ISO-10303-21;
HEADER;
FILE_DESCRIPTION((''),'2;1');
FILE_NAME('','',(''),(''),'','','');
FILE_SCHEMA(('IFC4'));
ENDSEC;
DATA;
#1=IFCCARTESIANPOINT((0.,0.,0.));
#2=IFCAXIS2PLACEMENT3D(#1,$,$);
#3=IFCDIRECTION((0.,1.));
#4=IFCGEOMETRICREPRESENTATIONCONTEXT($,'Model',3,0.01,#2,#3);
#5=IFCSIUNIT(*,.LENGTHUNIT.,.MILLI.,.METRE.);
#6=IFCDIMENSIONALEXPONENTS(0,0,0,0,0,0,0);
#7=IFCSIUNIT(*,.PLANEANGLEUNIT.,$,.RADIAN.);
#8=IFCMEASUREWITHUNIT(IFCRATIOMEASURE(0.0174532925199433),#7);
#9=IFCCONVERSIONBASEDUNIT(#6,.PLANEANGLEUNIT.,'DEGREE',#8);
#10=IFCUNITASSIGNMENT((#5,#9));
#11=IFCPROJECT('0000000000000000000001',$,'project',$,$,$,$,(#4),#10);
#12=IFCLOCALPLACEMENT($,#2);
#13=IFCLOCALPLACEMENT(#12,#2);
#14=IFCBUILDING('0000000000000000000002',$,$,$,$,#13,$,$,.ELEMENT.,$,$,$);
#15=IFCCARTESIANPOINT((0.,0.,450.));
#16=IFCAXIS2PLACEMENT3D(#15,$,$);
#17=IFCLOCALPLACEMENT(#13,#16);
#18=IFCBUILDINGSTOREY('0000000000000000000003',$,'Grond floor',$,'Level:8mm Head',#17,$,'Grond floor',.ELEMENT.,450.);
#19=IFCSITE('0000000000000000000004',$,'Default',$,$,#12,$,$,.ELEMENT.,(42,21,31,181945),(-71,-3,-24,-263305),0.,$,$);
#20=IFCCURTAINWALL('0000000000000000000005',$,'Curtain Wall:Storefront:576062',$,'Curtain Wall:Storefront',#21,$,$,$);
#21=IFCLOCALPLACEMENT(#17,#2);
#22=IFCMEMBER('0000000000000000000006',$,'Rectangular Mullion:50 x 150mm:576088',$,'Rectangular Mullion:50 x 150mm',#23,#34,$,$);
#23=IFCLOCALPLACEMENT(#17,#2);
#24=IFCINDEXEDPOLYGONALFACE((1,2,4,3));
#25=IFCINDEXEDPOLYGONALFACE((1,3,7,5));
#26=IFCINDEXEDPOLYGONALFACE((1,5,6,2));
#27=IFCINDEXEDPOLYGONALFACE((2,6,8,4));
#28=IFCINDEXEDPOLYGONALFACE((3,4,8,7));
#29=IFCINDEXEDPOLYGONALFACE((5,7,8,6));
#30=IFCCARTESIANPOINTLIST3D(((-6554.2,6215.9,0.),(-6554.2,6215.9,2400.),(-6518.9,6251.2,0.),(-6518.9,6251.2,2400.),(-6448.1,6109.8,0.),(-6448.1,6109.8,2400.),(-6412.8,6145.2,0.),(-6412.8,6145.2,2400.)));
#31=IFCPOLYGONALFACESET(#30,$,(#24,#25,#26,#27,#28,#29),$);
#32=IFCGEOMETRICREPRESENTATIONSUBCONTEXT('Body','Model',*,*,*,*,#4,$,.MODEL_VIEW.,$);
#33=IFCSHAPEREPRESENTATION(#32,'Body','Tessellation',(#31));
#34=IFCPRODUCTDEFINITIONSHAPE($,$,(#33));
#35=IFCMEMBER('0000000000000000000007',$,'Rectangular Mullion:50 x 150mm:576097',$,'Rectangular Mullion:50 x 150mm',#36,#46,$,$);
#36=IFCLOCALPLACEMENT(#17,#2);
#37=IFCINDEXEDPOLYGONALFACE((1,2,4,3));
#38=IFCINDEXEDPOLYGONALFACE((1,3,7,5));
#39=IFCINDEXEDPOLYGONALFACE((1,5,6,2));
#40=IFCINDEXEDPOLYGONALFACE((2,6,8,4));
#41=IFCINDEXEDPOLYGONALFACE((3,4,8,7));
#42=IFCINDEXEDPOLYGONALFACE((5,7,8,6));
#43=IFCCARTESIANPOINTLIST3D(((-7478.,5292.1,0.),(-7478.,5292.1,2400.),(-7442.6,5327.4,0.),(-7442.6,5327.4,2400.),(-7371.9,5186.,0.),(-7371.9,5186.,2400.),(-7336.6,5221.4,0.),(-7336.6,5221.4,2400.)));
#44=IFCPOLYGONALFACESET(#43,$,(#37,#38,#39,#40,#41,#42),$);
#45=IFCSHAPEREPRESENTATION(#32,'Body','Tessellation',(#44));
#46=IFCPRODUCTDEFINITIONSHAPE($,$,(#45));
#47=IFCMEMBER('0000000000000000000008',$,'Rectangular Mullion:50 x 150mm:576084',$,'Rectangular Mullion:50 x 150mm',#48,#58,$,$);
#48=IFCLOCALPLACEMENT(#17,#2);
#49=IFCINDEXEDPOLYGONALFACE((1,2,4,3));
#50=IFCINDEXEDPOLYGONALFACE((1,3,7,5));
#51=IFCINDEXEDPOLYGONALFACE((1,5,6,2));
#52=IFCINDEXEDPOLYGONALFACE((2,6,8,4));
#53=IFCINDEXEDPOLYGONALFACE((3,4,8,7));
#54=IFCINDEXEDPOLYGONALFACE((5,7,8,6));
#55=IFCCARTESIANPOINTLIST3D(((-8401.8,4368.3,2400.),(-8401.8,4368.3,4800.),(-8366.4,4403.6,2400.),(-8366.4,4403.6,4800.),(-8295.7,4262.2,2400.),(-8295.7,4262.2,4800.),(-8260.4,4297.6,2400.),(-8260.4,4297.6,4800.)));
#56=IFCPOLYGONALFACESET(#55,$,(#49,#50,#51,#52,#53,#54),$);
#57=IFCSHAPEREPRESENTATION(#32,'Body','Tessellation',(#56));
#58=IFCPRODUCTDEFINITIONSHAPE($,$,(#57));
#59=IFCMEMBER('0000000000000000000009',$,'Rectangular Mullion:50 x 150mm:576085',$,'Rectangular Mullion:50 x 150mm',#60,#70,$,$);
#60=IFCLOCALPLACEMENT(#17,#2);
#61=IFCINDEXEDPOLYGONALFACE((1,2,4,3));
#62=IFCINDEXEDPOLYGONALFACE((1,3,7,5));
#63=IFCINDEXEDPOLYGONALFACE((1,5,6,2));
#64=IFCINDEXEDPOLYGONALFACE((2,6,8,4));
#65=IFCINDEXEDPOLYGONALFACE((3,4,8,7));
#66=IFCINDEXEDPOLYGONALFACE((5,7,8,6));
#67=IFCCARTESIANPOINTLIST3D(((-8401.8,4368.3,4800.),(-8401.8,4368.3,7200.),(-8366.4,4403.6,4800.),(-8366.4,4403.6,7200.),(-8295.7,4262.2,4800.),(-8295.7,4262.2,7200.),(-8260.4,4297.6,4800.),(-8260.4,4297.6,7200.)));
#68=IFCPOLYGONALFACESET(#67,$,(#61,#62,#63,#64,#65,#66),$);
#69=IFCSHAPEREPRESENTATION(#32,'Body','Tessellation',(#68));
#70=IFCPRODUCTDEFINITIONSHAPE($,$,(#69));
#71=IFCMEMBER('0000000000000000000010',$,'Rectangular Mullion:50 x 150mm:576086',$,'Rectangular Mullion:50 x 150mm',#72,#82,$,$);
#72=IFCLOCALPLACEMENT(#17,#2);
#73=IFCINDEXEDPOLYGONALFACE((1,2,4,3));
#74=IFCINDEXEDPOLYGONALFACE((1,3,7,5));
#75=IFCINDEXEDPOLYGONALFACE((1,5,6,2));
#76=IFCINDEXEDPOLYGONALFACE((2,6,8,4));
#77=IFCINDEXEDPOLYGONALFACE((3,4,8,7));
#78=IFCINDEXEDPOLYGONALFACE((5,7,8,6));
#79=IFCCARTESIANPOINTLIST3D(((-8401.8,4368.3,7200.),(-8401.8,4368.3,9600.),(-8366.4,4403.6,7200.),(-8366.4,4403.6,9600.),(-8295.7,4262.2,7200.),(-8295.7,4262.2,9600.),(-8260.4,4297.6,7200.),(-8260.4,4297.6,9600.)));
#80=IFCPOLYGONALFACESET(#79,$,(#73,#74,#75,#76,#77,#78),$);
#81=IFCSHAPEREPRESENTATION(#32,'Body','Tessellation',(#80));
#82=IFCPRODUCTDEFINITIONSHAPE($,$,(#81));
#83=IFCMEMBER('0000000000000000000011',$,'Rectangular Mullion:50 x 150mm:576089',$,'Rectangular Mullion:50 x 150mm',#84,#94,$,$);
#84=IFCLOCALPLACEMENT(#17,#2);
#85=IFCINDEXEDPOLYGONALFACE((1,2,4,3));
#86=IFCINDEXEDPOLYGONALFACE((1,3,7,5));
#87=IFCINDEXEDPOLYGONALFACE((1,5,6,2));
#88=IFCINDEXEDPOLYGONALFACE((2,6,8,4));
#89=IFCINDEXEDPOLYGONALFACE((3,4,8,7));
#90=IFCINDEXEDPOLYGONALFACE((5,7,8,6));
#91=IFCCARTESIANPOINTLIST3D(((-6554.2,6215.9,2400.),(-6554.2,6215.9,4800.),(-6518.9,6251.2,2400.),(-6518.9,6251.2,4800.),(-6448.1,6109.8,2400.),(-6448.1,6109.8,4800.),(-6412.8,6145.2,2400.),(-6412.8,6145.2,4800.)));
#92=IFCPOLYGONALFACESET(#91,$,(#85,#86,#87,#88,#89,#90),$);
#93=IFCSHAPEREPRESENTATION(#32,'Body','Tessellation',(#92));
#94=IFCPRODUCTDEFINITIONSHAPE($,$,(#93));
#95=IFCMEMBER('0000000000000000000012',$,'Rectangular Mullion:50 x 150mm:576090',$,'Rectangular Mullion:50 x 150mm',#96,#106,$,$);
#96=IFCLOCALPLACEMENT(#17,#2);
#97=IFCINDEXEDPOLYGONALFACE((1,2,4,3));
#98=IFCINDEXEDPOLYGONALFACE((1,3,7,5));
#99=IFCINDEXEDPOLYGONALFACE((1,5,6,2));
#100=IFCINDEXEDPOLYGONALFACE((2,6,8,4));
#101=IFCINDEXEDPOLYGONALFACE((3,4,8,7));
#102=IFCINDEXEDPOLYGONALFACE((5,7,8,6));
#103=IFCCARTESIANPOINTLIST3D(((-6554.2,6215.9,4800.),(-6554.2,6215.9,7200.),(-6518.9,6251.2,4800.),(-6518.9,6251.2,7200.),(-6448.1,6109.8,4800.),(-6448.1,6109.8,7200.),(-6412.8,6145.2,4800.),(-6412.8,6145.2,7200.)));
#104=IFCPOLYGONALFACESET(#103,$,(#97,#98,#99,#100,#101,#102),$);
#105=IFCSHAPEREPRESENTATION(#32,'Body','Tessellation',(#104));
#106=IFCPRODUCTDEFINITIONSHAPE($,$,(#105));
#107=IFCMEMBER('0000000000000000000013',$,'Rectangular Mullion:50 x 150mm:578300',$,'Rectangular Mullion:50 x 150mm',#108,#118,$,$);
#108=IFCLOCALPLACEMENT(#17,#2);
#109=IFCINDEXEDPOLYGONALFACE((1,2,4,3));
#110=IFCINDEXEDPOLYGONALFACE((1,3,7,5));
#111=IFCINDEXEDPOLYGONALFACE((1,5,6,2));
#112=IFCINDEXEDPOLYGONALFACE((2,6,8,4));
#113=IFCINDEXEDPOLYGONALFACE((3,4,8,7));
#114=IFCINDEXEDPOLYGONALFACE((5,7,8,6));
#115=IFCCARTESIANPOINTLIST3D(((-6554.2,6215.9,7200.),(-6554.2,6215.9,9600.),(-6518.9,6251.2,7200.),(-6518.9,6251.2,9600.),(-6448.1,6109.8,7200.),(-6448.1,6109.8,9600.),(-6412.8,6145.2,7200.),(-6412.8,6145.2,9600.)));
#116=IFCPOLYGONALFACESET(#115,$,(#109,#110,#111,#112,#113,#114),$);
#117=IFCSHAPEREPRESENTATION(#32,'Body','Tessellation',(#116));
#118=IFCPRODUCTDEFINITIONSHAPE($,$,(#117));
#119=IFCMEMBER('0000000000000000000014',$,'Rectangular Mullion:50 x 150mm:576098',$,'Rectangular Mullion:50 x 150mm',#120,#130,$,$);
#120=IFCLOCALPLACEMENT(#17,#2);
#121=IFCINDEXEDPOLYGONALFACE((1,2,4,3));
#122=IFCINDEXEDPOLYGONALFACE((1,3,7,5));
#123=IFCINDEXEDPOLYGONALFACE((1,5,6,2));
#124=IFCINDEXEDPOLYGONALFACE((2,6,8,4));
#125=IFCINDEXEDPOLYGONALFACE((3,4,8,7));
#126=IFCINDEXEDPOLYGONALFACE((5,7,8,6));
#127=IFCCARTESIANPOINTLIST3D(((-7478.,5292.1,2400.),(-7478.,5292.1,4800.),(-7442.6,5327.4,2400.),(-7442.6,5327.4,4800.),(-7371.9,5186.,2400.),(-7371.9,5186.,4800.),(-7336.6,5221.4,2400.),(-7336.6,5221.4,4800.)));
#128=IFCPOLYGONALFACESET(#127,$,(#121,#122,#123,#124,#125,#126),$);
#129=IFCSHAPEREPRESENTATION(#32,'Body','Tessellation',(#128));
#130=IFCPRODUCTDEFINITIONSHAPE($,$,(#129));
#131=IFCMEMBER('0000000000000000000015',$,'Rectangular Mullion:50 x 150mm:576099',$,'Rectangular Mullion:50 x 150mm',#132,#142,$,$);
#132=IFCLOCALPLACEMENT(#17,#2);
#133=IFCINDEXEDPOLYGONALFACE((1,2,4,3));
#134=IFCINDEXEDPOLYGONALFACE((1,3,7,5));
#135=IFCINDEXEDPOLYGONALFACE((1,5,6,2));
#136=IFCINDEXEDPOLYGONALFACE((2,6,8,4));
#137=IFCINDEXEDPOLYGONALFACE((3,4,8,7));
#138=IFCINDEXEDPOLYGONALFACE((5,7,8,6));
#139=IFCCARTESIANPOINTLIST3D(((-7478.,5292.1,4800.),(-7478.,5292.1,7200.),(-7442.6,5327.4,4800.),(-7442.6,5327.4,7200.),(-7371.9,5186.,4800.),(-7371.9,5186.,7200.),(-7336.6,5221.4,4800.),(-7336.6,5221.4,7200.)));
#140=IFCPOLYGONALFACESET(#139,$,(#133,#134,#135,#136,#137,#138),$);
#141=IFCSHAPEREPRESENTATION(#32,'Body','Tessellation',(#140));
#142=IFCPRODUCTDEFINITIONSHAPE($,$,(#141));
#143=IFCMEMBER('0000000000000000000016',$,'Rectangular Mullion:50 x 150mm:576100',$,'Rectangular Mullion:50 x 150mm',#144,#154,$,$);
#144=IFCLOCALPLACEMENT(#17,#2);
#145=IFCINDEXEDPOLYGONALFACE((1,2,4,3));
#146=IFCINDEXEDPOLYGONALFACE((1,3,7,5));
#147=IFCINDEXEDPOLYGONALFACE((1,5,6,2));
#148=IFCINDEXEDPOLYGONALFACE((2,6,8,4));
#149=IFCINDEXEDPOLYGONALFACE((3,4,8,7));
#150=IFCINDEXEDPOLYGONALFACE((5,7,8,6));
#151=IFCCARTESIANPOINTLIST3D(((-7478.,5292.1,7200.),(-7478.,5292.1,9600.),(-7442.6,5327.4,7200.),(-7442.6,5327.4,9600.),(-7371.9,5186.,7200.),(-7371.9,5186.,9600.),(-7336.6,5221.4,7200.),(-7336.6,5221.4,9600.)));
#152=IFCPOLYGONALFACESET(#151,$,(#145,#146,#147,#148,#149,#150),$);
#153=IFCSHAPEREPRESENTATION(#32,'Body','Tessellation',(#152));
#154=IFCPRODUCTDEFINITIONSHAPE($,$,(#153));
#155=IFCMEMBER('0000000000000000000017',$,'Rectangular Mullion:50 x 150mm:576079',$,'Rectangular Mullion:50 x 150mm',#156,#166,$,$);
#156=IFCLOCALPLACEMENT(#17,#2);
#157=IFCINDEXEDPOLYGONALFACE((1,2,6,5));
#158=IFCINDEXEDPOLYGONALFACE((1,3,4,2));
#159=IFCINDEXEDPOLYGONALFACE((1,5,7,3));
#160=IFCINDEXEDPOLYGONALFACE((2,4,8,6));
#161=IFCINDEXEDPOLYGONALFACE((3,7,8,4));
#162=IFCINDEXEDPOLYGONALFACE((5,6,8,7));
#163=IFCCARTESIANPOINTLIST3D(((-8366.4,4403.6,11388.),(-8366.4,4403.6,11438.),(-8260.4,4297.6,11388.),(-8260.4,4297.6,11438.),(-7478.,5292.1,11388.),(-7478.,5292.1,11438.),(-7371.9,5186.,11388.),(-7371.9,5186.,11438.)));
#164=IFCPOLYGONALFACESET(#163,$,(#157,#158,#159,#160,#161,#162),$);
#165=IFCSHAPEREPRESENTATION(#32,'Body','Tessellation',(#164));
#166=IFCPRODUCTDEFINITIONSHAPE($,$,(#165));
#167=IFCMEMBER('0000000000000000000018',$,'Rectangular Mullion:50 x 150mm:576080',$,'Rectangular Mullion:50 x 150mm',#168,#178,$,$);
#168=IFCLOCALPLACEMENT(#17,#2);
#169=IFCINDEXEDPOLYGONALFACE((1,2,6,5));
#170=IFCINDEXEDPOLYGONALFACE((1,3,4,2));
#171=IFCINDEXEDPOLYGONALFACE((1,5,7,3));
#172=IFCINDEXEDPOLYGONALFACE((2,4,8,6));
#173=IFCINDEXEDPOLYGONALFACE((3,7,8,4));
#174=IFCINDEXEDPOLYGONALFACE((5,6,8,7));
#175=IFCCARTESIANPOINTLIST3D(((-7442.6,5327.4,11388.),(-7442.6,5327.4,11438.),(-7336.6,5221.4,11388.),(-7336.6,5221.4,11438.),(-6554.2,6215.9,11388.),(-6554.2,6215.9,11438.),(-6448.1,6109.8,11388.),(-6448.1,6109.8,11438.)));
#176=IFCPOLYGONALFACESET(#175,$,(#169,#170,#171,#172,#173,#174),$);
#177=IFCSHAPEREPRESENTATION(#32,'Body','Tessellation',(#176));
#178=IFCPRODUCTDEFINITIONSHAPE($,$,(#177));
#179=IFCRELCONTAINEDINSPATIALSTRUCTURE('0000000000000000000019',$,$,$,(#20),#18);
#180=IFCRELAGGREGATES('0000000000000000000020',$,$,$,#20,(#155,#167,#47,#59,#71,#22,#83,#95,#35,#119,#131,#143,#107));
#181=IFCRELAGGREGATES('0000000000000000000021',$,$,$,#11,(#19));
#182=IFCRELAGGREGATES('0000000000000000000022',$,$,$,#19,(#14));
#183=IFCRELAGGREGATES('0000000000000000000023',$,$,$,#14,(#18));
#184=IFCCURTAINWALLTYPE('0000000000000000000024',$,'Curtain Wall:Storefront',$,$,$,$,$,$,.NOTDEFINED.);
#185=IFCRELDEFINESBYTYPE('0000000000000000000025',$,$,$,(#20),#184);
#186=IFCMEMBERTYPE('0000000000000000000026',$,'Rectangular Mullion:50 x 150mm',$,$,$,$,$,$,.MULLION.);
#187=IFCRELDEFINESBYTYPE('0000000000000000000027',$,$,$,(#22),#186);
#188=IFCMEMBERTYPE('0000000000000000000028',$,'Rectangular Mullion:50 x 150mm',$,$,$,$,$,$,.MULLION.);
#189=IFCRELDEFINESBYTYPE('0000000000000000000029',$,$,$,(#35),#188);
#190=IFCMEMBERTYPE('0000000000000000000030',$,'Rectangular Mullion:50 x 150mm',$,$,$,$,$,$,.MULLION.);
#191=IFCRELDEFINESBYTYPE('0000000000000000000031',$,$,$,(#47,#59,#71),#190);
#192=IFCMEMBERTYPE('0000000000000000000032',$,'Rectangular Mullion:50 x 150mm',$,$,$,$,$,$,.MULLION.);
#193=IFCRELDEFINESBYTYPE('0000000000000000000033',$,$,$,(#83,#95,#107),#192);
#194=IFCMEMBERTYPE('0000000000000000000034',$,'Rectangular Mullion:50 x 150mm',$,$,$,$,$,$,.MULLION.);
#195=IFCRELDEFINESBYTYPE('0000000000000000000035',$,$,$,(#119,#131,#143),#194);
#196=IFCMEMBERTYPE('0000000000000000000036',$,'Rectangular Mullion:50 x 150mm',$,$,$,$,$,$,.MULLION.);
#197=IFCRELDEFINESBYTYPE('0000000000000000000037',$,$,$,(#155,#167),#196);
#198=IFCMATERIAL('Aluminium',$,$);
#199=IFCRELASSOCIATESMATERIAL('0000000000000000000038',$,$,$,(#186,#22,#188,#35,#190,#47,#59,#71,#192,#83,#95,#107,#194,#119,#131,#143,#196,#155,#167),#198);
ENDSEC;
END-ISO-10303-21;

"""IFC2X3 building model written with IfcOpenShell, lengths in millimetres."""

from ifc_helpers import new_model, entity, si_unit, converted_unit, direction, frame, origin, origin_2d_with_axis, place, context, subcontext, project, spatial, rectangle, extrude, source, transform, mapped, material, type_object, type_shapes, element, aggregate, save


model = new_model("IFC2X3")

# Units and contexts
model_context = context("Model", 3, precision=0.01, world=origin(), true_north=direction((0.0, 1.0)))
body_context = subcontext(model_context, "Body", "Model", "MODEL_VIEW")
ifc_project = project(units=[si_unit("LENGTHUNIT", "METRE", prefix="MILLI"), converted_unit("PLANEANGLEUNIT", "DEGREE", entity("IfcRatioMeasure", 0.0174532925199433), si_unit("PLANEANGLEUNIT", "RADIAN"), dimensions=[0, 0, 0, 0, 0, 0, 0])], contexts=[model_context])

# Site, building, storey
site_placement = place(None, origin())
site = spatial("IfcSite", under=ifc_project, at=site_placement, Name="Default", CompositionType="ELEMENT", RefLatitude=(42, 21, 31, 181945), RefLongitude=(-71, -3, -24, -263305), RefElevation=0.0)
building_placement = place(site_placement, origin())
building = spatial("IfcBuilding", under=site, at=building_placement, CompositionType="ELEMENT")
storey_placement = place(building_placement, frame((0.0, 0.0, 450.0)))
storey = spatial("IfcBuildingStorey", under=building, at=storey_placement, Name="Grond floor", ObjectType="Level:8mm Head", LongName="Grond floor", CompositionType="ELEMENT", Elevation=450.0)

# Curtain wall, members
curtain_wall_type = type_object("IfcCurtainWallType", Name="Curtain Wall:Storefront", PredefinedType="NOTDEFINED")
curtain_wall_placement = place(storey_placement, frame((0.0, 0.0, -450.0)))
curtain_wall = element("IfcCurtainWall", 1, at=curtain_wall_placement, inside=storey, type_object=curtain_wall_type, Name="Curtain Wall:Storefront:576062", ObjectType="Curtain Wall:Storefront")
ifc_material_1 = material(Name="Aluminium")
member_type_1 = type_object("IfcMemberType", Name="Rectangular Mullion:50 x 150mm", PredefinedType="MULLION", material=ifc_material_1)
shared_shape_1 = source(origin(), body_context, "Body", "SweptSolid", [
    extrude(rectangle(XDim=150.0, YDim=50.0, at=origin_2d_with_axis()), frame((-25.0, 0.0, -2400.0), z_axis=(0.0, 0.0, 1.0), x_axis=(0.0, -1.0, 0.0)), (0.0, 0.0, 1.0), 2400.0),
])
type_shapes(member_type_1, [shared_shape_1])
member_1_placement = place(storey_placement, frame((-6465.8, 6198.2, 2400.0), z_axis=(0.0, 0.0, 1.0), x_axis=(0.707107, 0.707107, 0.0)))
member_1 = element("IfcMember", 2, at=member_1_placement, type_object=member_type_1, material=ifc_material_1, Name="Rectangular Mullion:50 x 150mm:576088", ObjectType="Rectangular Mullion:50 x 150mm", context=body_context, shape_type="MappedRepresentation", body=[
    mapped(shared_shape_1, transform((0.0, 0.0, 0.0), scale=1.0)),
])
member_type_2 = type_object("IfcMemberType", Name="Rectangular Mullion:50 x 150mm", PredefinedType="MULLION", material=ifc_material_1)
shared_shape_2 = source(origin(), body_context, "Body", "SweptSolid", [
    extrude(rectangle(XDim=150.0, YDim=50.0, at=origin_2d_with_axis()), frame((0.0, 0.0, -2400.0), z_axis=(0.0, 0.0, 1.0), x_axis=(0.0, -1.0, 0.0)), (0.0, 0.0, 1.0), 2400.0),
])
type_shapes(member_type_2, [shared_shape_2])
member_2_placement = place(storey_placement, frame((-7407.3, 5256.7, 0.0), z_axis=(0.0, 0.0, -1.0), x_axis=(-0.707107, -0.707107, 0.0)))
member_2 = element("IfcMember", 3, at=member_2_placement, type_object=member_type_2, material=ifc_material_1, Name="Rectangular Mullion:50 x 150mm:576097", ObjectType="Rectangular Mullion:50 x 150mm", context=body_context, shape_type="MappedRepresentation", body=[
    mapped(shared_shape_2, transform((0.0, 0.0, 0.0), scale=1.0)),
])
member_type_3 = type_object("IfcMemberType", Name="Rectangular Mullion:50 x 150mm", PredefinedType="MULLION", material=ifc_material_1)
shared_shape_3 = source(origin(), body_context, "Body", "SweptSolid", [
    extrude(rectangle(XDim=150.0, YDim=50.0, at=origin_2d_with_axis()), frame((-25.0, 0.0, -2400.0), z_axis=(0.0, 0.0, 1.0), x_axis=(0.0, -1.0, 0.0)), (0.0, 0.0, 1.0), 2400.0),
])
type_shapes(member_type_3, [shared_shape_3])
member_3_placement = place(storey_placement, frame((-8348.8, 4315.3, 2400.0), z_axis=(0.0, 0.0, -1.0), x_axis=(-0.707107, -0.707107, 0.0)))
member_3 = element("IfcMember", 4, at=member_3_placement, type_object=member_type_3, material=ifc_material_1, Name="Rectangular Mullion:50 x 150mm:576084", ObjectType="Rectangular Mullion:50 x 150mm", context=body_context, shape_type="MappedRepresentation", body=[
    mapped(shared_shape_3, transform((0.0, 0.0, 0.0), scale=1.0)),
])
member_4_placement = place(storey_placement, frame((-8348.8, 4315.3, 4800.0), z_axis=(0.0, 0.0, -1.0), x_axis=(-0.707107, -0.707107, 0.0)))
member_4 = element("IfcMember", 5, at=member_4_placement, type_object=member_type_3, material=ifc_material_1, Name="Rectangular Mullion:50 x 150mm:576085", ObjectType="Rectangular Mullion:50 x 150mm", context=body_context, shape_type="MappedRepresentation", body=[
    mapped(shared_shape_3, transform((0.0, 0.0, 0.0), scale=1.0)),
])
member_5_placement = place(storey_placement, frame((-8348.8, 4315.3, 7200.0), z_axis=(0.0, 0.0, -1.0), x_axis=(-0.707107, -0.707107, 0.0)))
member_5 = element("IfcMember", 6, at=member_5_placement, type_object=member_type_3, material=ifc_material_1, Name="Rectangular Mullion:50 x 150mm:576086", ObjectType="Rectangular Mullion:50 x 150mm", context=body_context, shape_type="MappedRepresentation", body=[
    mapped(shared_shape_3, transform((0.0, 0.0, 0.0), scale=1.0)),
])
member_type_4 = type_object("IfcMemberType", Name="Rectangular Mullion:50 x 150mm", PredefinedType="MULLION", material=ifc_material_1)
shared_shape_4 = source(origin(), body_context, "Body", "SweptSolid", [
    extrude(rectangle(XDim=150.0, YDim=50.0, at=origin_2d_with_axis()), frame((-25.0, 0.0, -2400.0), z_axis=(0.0, 0.0, 1.0), x_axis=(0.0, -1.0, 0.0)), (0.0, 0.0, 1.0), 2400.0),
])
type_shapes(member_type_4, [shared_shape_4])
member_6_placement = place(storey_placement, frame((-6465.8, 6198.2, 4800.0), z_axis=(0.0, 0.0, 1.0), x_axis=(0.707107, 0.707107, 0.0)))
member_6 = element("IfcMember", 7, at=member_6_placement, type_object=member_type_4, material=ifc_material_1, Name="Rectangular Mullion:50 x 150mm:576089", ObjectType="Rectangular Mullion:50 x 150mm", context=body_context, shape_type="MappedRepresentation", body=[
    mapped(shared_shape_4, transform((0.0, 0.0, 0.0), scale=1.0)),
])
member_7_placement = place(storey_placement, frame((-6465.8, 6198.2, 7200.0), z_axis=(0.0, 0.0, 1.0), x_axis=(0.707107, 0.707107, 0.0)))
member_7 = element("IfcMember", 8, at=member_7_placement, type_object=member_type_4, material=ifc_material_1, Name="Rectangular Mullion:50 x 150mm:576090", ObjectType="Rectangular Mullion:50 x 150mm", context=body_context, shape_type="MappedRepresentation", body=[
    mapped(shared_shape_4, transform((0.0, 0.0, 0.0), scale=1.0)),
])
member_8_placement = place(storey_placement, frame((-6465.8, 6198.2, 9600.0), z_axis=(0.0, 0.0, 1.0), x_axis=(0.707107, 0.707107, 0.0)))
member_8 = element("IfcMember", 9, at=member_8_placement, type_object=member_type_4, material=ifc_material_1, Name="Rectangular Mullion:50 x 150mm:578300", ObjectType="Rectangular Mullion:50 x 150mm", context=body_context, shape_type="MappedRepresentation", body=[
    mapped(shared_shape_4, transform((0.0, 0.0, 0.0), scale=1.0)),
])
member_type_5 = type_object("IfcMemberType", Name="Rectangular Mullion:50 x 150mm", PredefinedType="MULLION", material=ifc_material_1)
shared_shape_5 = source(origin(), body_context, "Body", "SweptSolid", [
    extrude(rectangle(XDim=150.0, YDim=50.0, at=origin_2d_with_axis()), frame((0.0, 0.0, -2400.0), z_axis=(0.0, 0.0, 1.0), x_axis=(0.0, -1.0, 0.0)), (0.0, 0.0, 1.0), 2400.0),
])
type_shapes(member_type_5, [shared_shape_5])
member_9_placement = place(storey_placement, frame((-7407.3, 5256.7, 2400.0), z_axis=(0.0, 0.0, -1.0), x_axis=(-0.707107, -0.707107, 0.0)))
member_9 = element("IfcMember", 10, at=member_9_placement, type_object=member_type_5, material=ifc_material_1, Name="Rectangular Mullion:50 x 150mm:576098", ObjectType="Rectangular Mullion:50 x 150mm", context=body_context, shape_type="MappedRepresentation", body=[
    mapped(shared_shape_5, transform((0.0, 0.0, 0.0), scale=1.0)),
])
member_10_placement = place(storey_placement, frame((-7407.3, 5256.7, 4800.0), z_axis=(0.0, 0.0, -1.0), x_axis=(-0.707107, -0.707107, 0.0)))
member_10 = element("IfcMember", 11, at=member_10_placement, type_object=member_type_5, material=ifc_material_1, Name="Rectangular Mullion:50 x 150mm:576099", ObjectType="Rectangular Mullion:50 x 150mm", context=body_context, shape_type="MappedRepresentation", body=[
    mapped(shared_shape_5, transform((0.0, 0.0, 0.0), scale=1.0)),
])
member_11_placement = place(storey_placement, frame((-7407.3, 5256.7, 7200.0), z_axis=(0.0, 0.0, -1.0), x_axis=(-0.707107, -0.707107, 0.0)))
member_11 = element("IfcMember", 12, at=member_11_placement, type_object=member_type_5, material=ifc_material_1, Name="Rectangular Mullion:50 x 150mm:576100", ObjectType="Rectangular Mullion:50 x 150mm", context=body_context, shape_type="MappedRepresentation", body=[
    mapped(shared_shape_5, transform((0.0, 0.0, 0.0), scale=1.0)),
])
member_type_6 = type_object("IfcMemberType", Name="Rectangular Mullion:50 x 150mm", PredefinedType="MULLION", material=ifc_material_1)
shared_shape_6 = source(origin(), body_context, "Body", "SweptSolid", [
    extrude(rectangle(XDim=150.0, YDim=50.0, at=origin_2d_with_axis()), frame((-25.0, 0.0, -1256.4), z_axis=(0.0, 0.0, 1.0), x_axis=(0.0, -1.0, 0.0)), (0.0, 0.0, 1.0), 1256.4),
])
type_shapes(member_type_6, [shared_shape_6])
member_12_placement = place(storey_placement, frame((-8313.4, 4350.6, 11438.0), z_axis=(-0.707107, -0.707107, 0.0), x_axis=(0.0, 0.0, 1.0)))
member_12 = element("IfcMember", 13, at=member_12_placement, type_object=member_type_6, material=ifc_material_1, Name="Rectangular Mullion:50 x 150mm:576079", ObjectType="Rectangular Mullion:50 x 150mm", context=body_context, shape_type="MappedRepresentation", body=[
    mapped(shared_shape_6, transform((0.0, 0.0, 0.0), scale=1.0)),
])
member_13_placement = place(storey_placement, frame((-7389.6, 5274.4, 11438.0), z_axis=(-0.707107, -0.707107, 0.0), x_axis=(0.0, 0.0, 1.0)))
member_13 = element("IfcMember", 14, at=member_13_placement, type_object=member_type_6, material=ifc_material_1, Name="Rectangular Mullion:50 x 150mm:576080", ObjectType="Rectangular Mullion:50 x 150mm", context=body_context, shape_type="MappedRepresentation", body=[
    mapped(shared_shape_6, transform((0.0, 0.0, 0.0), scale=1.0)),
])
aggregate(curtain_wall, [member_12, member_13, member_3, member_4, member_5, member_1, member_6, member_7, member_2, member_9, member_10, member_11, member_8])

save(model, "model.ifc")
